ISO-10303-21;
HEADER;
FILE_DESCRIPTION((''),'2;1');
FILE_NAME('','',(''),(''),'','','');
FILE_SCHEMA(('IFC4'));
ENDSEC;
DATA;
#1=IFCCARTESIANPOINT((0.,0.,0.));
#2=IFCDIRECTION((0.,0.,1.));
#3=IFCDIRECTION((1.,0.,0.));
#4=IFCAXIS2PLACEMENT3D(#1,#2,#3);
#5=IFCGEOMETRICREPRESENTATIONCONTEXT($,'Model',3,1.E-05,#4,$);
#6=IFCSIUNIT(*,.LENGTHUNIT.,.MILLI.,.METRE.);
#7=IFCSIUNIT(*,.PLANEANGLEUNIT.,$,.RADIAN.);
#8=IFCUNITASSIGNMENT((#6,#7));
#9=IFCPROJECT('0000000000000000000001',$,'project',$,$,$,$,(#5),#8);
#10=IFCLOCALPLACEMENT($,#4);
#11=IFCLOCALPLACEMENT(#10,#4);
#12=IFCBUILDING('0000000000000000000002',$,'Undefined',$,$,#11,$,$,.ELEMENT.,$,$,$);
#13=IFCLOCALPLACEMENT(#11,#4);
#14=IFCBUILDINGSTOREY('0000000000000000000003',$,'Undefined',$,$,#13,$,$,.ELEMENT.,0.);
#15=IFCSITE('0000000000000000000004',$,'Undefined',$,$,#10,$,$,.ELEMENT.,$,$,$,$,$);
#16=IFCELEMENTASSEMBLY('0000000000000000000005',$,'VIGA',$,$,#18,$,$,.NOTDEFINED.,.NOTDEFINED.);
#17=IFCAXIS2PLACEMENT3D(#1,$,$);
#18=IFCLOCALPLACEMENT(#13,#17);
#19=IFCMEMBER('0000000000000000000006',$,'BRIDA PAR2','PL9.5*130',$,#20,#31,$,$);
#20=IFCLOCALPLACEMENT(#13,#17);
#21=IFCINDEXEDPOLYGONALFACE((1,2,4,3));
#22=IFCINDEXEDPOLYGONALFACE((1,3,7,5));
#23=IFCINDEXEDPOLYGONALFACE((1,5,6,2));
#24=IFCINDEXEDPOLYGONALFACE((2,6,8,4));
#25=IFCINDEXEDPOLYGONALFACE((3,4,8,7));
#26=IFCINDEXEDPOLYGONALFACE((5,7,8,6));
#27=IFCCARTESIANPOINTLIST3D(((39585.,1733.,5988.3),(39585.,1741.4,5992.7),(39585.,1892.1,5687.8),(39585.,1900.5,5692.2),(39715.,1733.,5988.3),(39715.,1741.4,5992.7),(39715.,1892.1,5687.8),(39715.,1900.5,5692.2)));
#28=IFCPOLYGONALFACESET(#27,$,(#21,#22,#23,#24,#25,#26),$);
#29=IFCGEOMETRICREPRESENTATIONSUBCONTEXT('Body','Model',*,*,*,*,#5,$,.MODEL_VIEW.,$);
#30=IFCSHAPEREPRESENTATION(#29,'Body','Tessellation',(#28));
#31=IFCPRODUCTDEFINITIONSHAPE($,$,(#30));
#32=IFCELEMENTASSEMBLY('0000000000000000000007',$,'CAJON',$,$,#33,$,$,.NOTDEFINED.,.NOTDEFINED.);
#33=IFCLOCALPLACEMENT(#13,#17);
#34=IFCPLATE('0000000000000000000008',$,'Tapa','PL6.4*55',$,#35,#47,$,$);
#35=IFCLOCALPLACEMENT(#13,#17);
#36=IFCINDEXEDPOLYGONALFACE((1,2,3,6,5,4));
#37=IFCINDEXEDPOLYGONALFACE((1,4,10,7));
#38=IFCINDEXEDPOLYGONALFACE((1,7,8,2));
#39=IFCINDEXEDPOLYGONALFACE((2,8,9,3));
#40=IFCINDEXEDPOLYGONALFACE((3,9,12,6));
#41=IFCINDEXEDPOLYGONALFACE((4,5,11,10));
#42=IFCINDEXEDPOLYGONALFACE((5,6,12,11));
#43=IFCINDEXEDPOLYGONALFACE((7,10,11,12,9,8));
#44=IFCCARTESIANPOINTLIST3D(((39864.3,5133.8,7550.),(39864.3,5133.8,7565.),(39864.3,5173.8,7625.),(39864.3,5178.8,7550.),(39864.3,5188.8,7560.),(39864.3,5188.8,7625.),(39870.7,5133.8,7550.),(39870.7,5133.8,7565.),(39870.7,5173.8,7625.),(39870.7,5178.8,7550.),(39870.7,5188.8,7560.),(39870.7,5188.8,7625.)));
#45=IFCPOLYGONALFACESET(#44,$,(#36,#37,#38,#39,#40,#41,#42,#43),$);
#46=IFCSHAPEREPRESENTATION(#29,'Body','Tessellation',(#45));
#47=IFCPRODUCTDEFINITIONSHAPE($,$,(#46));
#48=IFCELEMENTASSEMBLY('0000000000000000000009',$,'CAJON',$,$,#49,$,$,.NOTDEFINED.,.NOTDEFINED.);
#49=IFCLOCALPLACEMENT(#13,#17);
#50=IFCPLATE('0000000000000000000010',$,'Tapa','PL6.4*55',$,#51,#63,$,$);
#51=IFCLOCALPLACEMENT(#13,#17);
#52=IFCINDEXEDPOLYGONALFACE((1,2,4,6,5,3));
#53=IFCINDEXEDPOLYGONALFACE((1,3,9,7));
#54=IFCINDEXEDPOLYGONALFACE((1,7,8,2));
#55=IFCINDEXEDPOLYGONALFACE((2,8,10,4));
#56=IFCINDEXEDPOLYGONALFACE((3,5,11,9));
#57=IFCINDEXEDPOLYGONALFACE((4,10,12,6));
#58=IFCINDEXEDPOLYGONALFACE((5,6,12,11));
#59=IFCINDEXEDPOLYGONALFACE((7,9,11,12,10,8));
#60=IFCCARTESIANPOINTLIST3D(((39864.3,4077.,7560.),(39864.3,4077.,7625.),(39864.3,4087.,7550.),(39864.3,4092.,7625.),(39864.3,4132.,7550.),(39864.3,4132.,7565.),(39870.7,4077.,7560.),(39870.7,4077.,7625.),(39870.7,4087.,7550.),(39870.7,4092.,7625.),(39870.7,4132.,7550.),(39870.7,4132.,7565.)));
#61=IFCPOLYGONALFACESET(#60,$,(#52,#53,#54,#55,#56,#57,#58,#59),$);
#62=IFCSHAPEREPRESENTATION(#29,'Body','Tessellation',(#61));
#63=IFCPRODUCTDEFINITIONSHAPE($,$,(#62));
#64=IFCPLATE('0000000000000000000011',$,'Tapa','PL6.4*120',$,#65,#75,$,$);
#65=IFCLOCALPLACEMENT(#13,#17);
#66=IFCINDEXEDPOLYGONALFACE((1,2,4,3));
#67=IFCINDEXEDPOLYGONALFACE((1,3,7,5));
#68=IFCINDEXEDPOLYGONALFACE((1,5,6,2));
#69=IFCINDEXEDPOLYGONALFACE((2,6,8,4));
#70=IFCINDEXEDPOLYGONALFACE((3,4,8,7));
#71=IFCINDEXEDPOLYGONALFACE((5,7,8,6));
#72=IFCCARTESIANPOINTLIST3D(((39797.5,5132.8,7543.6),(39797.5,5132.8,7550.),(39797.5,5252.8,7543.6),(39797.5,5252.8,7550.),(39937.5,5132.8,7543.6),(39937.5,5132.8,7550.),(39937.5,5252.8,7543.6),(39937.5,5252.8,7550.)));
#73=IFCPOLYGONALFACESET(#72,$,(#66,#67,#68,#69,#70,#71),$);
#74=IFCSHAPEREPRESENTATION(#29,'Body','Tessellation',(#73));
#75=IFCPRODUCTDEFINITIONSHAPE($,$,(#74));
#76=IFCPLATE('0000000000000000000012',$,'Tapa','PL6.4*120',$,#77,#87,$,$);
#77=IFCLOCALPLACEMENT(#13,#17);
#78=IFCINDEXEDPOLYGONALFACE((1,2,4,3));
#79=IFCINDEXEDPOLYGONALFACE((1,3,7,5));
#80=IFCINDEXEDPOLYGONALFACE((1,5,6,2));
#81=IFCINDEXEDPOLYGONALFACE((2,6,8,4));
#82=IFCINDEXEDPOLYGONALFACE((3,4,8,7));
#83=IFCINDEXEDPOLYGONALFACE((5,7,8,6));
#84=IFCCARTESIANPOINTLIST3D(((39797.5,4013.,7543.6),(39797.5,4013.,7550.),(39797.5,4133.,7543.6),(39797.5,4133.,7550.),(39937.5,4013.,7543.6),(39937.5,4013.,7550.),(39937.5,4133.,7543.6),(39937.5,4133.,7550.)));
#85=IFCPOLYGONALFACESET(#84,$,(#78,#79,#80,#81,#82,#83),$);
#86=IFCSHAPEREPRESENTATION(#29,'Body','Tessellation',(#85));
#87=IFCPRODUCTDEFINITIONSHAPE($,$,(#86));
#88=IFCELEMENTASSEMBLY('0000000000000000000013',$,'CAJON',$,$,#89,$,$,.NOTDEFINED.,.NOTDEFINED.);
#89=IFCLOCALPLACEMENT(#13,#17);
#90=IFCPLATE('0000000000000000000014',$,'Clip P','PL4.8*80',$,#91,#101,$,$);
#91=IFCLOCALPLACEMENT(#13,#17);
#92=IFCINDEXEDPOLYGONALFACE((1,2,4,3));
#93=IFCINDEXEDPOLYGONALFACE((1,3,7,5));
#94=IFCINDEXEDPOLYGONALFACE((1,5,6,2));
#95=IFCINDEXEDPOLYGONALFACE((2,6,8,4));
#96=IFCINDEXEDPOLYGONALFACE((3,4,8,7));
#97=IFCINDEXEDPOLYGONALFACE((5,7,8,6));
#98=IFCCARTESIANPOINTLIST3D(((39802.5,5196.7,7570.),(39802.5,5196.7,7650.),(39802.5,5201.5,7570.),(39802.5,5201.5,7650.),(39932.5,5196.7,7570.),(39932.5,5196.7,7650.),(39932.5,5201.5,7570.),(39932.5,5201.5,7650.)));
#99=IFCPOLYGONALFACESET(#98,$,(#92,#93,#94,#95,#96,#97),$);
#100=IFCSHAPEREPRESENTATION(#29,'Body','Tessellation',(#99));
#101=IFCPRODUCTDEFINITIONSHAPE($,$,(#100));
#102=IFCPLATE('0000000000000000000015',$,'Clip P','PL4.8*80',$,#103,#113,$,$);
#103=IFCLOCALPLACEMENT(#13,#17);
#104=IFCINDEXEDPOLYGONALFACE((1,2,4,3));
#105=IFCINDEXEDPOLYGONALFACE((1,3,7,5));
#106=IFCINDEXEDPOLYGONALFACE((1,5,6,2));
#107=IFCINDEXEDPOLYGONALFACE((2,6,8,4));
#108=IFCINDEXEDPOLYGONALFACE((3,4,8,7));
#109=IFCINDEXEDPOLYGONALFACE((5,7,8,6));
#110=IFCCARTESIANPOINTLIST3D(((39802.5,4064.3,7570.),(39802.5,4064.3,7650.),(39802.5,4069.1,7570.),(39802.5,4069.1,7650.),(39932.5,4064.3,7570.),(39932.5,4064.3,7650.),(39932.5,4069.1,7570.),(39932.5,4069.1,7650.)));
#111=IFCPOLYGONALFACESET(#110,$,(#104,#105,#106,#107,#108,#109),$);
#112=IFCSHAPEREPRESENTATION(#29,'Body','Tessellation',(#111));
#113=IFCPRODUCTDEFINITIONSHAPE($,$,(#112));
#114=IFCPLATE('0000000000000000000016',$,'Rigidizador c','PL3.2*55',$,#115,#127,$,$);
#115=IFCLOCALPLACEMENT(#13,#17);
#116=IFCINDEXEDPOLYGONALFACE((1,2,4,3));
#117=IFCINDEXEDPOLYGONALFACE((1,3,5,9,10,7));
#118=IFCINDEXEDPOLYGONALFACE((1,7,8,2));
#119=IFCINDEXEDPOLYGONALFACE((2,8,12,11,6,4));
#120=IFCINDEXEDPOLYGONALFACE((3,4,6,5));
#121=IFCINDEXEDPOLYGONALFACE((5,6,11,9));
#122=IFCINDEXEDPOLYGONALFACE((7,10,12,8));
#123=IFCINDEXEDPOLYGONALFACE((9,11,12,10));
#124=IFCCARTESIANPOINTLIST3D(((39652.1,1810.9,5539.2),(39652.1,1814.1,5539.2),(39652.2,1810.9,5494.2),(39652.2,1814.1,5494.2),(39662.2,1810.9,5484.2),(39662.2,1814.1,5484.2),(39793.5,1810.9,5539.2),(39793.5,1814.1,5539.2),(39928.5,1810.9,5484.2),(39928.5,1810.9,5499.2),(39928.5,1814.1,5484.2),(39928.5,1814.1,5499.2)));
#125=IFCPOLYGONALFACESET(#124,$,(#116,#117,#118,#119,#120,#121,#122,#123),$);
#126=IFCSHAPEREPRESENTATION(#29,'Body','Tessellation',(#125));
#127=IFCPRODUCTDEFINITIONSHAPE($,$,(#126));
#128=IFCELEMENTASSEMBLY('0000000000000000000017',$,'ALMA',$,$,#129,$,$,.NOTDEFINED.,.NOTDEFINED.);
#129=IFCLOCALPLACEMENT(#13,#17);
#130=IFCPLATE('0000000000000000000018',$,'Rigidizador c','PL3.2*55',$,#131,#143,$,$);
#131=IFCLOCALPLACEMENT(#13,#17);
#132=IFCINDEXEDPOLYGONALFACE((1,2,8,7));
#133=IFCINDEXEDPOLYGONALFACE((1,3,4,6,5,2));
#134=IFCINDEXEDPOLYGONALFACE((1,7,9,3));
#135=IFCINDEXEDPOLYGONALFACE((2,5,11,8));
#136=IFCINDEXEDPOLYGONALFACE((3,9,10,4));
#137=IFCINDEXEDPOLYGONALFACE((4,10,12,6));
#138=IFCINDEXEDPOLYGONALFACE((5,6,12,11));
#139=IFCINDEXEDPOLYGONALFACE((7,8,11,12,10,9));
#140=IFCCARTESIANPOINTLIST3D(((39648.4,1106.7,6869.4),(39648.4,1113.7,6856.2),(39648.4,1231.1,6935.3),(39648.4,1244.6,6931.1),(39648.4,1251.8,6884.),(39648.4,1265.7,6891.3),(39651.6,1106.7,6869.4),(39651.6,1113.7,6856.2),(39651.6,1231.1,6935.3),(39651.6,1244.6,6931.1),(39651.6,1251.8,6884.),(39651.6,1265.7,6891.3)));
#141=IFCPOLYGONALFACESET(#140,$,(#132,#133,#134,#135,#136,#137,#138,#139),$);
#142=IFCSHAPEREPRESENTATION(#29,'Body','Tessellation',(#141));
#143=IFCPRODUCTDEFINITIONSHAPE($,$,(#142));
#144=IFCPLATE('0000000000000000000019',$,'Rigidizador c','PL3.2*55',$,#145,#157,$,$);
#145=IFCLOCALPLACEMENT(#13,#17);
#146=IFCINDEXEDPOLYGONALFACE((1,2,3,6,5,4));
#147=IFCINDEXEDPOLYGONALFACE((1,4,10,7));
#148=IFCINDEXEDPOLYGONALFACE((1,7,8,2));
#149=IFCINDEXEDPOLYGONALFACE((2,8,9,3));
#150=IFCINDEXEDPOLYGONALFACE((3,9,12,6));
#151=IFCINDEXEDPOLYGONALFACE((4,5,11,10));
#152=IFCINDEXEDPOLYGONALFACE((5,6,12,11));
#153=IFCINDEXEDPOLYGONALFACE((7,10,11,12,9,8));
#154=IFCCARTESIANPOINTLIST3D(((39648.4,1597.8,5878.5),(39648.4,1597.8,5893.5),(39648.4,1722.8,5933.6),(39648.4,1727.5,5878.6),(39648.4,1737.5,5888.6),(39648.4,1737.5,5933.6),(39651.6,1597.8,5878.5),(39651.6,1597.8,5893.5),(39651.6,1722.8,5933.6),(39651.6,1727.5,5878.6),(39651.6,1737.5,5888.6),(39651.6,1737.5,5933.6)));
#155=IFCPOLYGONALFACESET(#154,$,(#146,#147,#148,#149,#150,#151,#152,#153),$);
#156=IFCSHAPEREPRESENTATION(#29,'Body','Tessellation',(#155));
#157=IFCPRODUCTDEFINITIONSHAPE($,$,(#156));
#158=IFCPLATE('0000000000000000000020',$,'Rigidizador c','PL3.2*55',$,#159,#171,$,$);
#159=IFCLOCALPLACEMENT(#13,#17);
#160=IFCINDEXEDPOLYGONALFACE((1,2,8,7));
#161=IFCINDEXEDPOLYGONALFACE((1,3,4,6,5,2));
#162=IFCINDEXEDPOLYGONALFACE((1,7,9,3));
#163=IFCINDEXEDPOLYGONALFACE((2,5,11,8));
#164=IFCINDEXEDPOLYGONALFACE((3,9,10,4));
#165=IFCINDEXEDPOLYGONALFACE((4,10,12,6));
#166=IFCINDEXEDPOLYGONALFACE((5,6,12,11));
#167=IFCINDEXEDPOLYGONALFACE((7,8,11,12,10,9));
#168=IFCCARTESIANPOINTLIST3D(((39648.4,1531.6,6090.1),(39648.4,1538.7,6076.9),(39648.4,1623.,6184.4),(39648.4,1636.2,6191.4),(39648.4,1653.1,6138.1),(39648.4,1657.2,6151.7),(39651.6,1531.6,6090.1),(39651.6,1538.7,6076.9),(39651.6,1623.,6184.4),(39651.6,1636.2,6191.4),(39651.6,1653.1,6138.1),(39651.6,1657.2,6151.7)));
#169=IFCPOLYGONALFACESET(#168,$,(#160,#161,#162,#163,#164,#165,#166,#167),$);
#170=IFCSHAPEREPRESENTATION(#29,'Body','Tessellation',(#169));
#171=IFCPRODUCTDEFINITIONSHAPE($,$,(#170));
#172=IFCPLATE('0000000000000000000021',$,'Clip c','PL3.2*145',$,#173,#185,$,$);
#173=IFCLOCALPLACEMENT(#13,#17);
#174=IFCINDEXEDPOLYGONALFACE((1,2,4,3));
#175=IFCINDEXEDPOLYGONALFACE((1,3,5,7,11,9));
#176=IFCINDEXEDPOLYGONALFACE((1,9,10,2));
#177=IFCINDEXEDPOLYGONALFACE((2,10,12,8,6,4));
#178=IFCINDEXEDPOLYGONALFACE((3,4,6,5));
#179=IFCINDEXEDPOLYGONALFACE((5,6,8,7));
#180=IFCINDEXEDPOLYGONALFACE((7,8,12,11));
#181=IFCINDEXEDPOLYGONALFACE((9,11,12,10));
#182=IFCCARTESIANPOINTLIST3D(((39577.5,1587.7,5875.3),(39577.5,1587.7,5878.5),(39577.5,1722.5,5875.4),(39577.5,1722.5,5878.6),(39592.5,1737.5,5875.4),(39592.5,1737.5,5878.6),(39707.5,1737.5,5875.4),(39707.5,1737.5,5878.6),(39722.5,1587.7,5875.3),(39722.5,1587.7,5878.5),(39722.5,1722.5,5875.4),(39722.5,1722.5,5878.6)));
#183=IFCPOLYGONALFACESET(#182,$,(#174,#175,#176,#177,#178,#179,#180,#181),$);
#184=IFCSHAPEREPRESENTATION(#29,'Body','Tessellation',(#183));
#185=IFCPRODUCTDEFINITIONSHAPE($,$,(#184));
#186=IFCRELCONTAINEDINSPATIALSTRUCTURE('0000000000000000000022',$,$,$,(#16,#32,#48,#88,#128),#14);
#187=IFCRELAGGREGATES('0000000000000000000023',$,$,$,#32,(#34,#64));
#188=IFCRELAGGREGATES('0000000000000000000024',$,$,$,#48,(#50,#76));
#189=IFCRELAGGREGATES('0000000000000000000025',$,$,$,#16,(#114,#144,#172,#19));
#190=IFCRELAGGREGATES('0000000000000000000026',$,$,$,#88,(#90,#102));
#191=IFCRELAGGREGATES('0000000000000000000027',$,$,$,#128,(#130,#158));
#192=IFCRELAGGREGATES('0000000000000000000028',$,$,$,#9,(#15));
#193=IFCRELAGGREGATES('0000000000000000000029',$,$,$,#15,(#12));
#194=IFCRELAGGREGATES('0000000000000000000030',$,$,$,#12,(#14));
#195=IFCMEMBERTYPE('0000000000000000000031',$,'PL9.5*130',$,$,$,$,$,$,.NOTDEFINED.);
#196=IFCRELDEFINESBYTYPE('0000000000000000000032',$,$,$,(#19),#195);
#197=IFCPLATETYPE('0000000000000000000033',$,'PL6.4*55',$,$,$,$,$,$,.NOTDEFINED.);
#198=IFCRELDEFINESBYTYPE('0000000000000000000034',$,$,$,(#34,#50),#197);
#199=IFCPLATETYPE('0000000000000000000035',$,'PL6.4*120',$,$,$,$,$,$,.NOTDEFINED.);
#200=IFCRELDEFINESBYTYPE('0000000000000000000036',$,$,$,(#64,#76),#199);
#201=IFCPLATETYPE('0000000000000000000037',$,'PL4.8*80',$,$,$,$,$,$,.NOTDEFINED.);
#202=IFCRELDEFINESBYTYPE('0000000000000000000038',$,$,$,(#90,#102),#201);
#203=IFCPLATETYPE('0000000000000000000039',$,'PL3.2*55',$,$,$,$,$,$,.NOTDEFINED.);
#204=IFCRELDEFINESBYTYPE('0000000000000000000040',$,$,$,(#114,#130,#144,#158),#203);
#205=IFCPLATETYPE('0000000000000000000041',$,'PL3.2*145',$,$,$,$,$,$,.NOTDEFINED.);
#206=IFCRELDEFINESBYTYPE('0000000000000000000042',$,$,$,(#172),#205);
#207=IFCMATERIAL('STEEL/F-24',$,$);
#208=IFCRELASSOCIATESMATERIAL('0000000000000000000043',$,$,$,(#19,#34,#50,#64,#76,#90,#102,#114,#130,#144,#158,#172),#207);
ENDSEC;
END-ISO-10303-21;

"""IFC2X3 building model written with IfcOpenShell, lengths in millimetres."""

from ifc_helpers import new_model, si_unit, frame, origin_with_axes, origin_2d_with_axis, place, context, subcontext, project, spatial, polyline, rectangle, outline, extrude, material, type_object, element, aggregate, save


model = new_model("IFC2X3")

# Units and contexts
model_context = context("Model", 3, precision=1e-05, world=origin_with_axes())
body_context = subcontext(model_context, "Body", "Model", "MODEL_VIEW")
ifc_project = project(units=[si_unit("LENGTHUNIT", "METRE", prefix="MILLI"), si_unit("PLANEANGLEUNIT", "RADIAN")], contexts=[model_context])

# Site, building, storey
site_placement = place(None, origin_with_axes())
site = spatial("IfcSite", under=ifc_project, at=site_placement, Name="Undefined", CompositionType="ELEMENT")
building_placement = place(site_placement, origin_with_axes())
building = spatial("IfcBuilding", under=site, at=building_placement, Name="Undefined", CompositionType="ELEMENT")
storey_placement = place(building_placement, origin_with_axes())
storey = spatial("IfcBuildingStorey", under=building, at=storey_placement, Name="Undefined", CompositionType="ELEMENT", Elevation=0.0)

# Element assembly, member
assembly_1_placement = place(storey_placement, origin_with_axes())
assembly_1 = element("IfcElementAssembly", 1, at=assembly_1_placement, inside=storey, Name="VIGA", AssemblyPlace="NOTDEFINED", PredefinedType="NOTDEFINED")
ifc_material_1 = material(Name="STEEL/F-24")
member_type = type_object("IfcMemberType", Name="PL9.5*130", PredefinedType="NOTDEFINED")
member_placement = place(assembly_1_placement, frame((39650.0, 1896.3, 5690.0), z_axis=(-1.0, 0.0, 0.0), x_axis=(0.0, -0.467888, 0.883788)))
member = element("IfcMember", 2, at=member_placement, type_object=member_type, material=ifc_material_1, Name="BRIDA PAR2", Description="PL9.5*130", context=body_context, shape_type="SweptSolid", body=[
    extrude(rectangle(XDim=9.5, YDim=130.0, at=origin_2d_with_axis()), frame((340.0, 0.0, 0.0), z_axis=(-1.0, 0.0, 0.0), x_axis=(0.0, -1.0, 0.0)), (0.0, 0.0, 1.0), 340.0),
])

# Element assemblies, plates
assembly_2_placement = place(storey_placement, origin_with_axes())
assembly_2 = element("IfcElementAssembly", 3, at=assembly_2_placement, inside=storey, Name="CAJON", AssemblyPlace="NOTDEFINED", PredefinedType="NOTDEFINED")
plate_type_1 = type_object("IfcPlateType", Name="PL6.4*55", PredefinedType="NOTDEFINED")
plate_1_placement = place(assembly_2_placement, frame((39867.5, 5188.8, 7625.0), z_axis=(-1.0, 0.0, 0.0), x_axis=(0.0, 0.000064, -1.0)))
plate_1 = element("IfcPlate", 4, at=plate_1_placement, type_object=plate_type_1, material=ifc_material_1, Name="Tapa", Description="PL6.4*55", context=body_context, shape_type="SweptSolid", body=[
    extrude(outline(polyline([(0.0, 0.0), (65.0, 0.0), (75.0, 10.0), (75.0, 55.0), (60.0, 55.0), (0.0, 15.0), (0.0, 0.0)])), frame((0.0, 0.0, -3.2), z_axis=(0.0, 0.0, 1.0), x_axis=(1.0, 0.0, 0.0)), (0.0, 0.0, 1.0), 6.4),
])
assembly_3_placement = place(storey_placement, origin_with_axes())
assembly_3 = element("IfcElementAssembly", 5, at=assembly_3_placement, inside=storey, Name="CAJON", AssemblyPlace="NOTDEFINED", PredefinedType="NOTDEFINED")
plate_2_placement = place(assembly_3_placement, frame((39867.5, 4077.0, 7625.0), z_axis=(1.0, 0.0, 0.0), x_axis=(0.0, -0.000064, -1.0)))
plate_2 = element("IfcPlate", 6, at=plate_2_placement, type_object=plate_type_1, material=ifc_material_1, Name="Tapa", Description="PL6.4*55", context=body_context, shape_type="SweptSolid", body=[
    extrude(outline(polyline([(0.0, 0.0), (65.0, 0.0), (75.0, 10.0), (75.0, 55.0), (60.0, 55.0), (0.0, 15.0), (0.0, 0.0)])), frame((0.0, 0.0, -3.2), z_axis=(0.0, 0.0, 1.0), x_axis=(1.0, 0.0, 0.0)), (0.0, 0.0, 1.0), 6.4),
])

# Plates
plate_type_2 = type_object("IfcPlateType", Name="PL6.4*120", PredefinedType="NOTDEFINED")
plate_3_placement = place(assembly_2_placement, frame((39937.5, 5132.8, 7546.8), z_axis=(0.0, -0.000039, 1.0), x_axis=(0.0, 1.0, 0.000039)))
plate_3 = element("IfcPlate", 7, at=plate_3_placement, type_object=plate_type_2, material=ifc_material_1, Name="Tapa", Description="PL6.4*120", context=body_context, shape_type="SweptSolid", body=[
    extrude(outline(polyline([(0.0, 0.0), (120.0, 0.0), (120.0, 140.0), (0.0, 140.0), (0.0, 0.0)])), frame((0.0, 0.0, -3.2), z_axis=(0.0, 0.0, 1.0), x_axis=(1.0, 0.0, 0.0)), (0.0, 0.0, 1.0), 6.4),
])
aggregate(assembly_2, [plate_1, plate_3])
plate_4_placement = place(assembly_3_placement, frame((39937.5, 4133.0, 7546.8), z_axis=(0.0, -0.000039, -1.0), x_axis=(0.0, -1.0, 0.000039)))
plate_4 = element("IfcPlate", 8, at=plate_4_placement, type_object=plate_type_2, material=ifc_material_1, Name="Tapa", Description="PL6.4*120", context=body_context, shape_type="SweptSolid", body=[
    extrude(outline(polyline([(0.0, 0.0), (120.0, 0.0), (120.0, 140.0), (0.0, 140.0), (0.0, 0.0)])), frame((0.0, 0.0, -3.2), z_axis=(0.0, 0.0, 1.0), x_axis=(1.0, 0.0, 0.0)), (0.0, 0.0, 1.0), 6.4),
])
aggregate(assembly_3, [plate_2, plate_4])

# Element assembly, plates
assembly_4_placement = place(storey_placement, origin_with_axes())
assembly_4 = element("IfcElementAssembly", 9, at=assembly_4_placement, inside=storey, Name="CAJON", AssemblyPlace="NOTDEFINED", PredefinedType="NOTDEFINED")
plate_type_3 = type_object("IfcPlateType", Name="PL4.8*80", PredefinedType="NOTDEFINED")
plate_5_placement = place(assembly_4_placement, frame((39802.5, 5199.1, 7570.0), z_axis=(0.0, -1.0, -0.000052), x_axis=(1.0, 0.0, 0.0)))
plate_5 = element("IfcPlate", 10, at=plate_5_placement, type_object=plate_type_3, material=ifc_material_1, Name="Clip P", Description="PL4.8*80", context=body_context, shape_type="SweptSolid", body=[
    extrude(outline(polyline([(0.0, 0.0), (130.0, 0.0), (130.0, 80.0), (0.0, 80.0), (0.0, 0.0)])), frame((0.0, 0.0, -2.4), z_axis=(0.0, 0.0, 1.0), x_axis=(1.0, 0.0, 0.0)), (0.0, 0.0, 1.0), 4.8),
])
plate_6_placement = place(assembly_4_placement, frame((39802.5, 4066.7, 7570.0), z_axis=(0.0, -1.0, 0.000052), x_axis=(1.0, 0.0, 0.0)))
plate_6 = element("IfcPlate", 11, at=plate_6_placement, type_object=plate_type_3, material=ifc_material_1, Name="Clip P", Description="PL4.8*80", context=body_context, shape_type="SweptSolid", body=[
    extrude(outline(polyline([(0.0, 0.0), (130.0, 0.0), (130.0, 80.0), (0.0, 80.0), (0.0, 0.0)])), frame((0.0, 0.0, -2.4), z_axis=(0.0, 0.0, 1.0), x_axis=(1.0, 0.0, 0.0)), (0.0, 0.0, 1.0), 4.8),
])

# Plate
plate_type_4 = type_object("IfcPlateType", Name="PL3.2*55", PredefinedType="NOTDEFINED")
plate_7_placement = place(assembly_1_placement, frame((39928.5, 1812.5, 5484.2), z_axis=(0.0, -1.0, 0.0), x_axis=(-0.000128, 0.0, 1.0)))
plate_7 = element("IfcPlate", 12, at=plate_7_placement, type_object=plate_type_4, material=ifc_material_1, Name="Rigidizador c", Description="PL3.2*55", context=body_context, shape_type="SweptSolid", body=[
    extrude(outline(polyline([(0.0, 0.0), (15.0, 0.0), (55.0, 135.0), (55.0, 276.4), (10.0, 276.3), (0.0, 266.3), (0.0, 0.0)])), frame((0.0, 0.0, -1.6), z_axis=(0.0, 0.0, 1.0), x_axis=(1.0, 0.0, 0.0)), (0.0, 0.0, 1.0), 3.2),
])

# Element assembly, plate
assembly_5_placement = place(storey_placement, origin_with_axes())
assembly_5 = element("IfcElementAssembly", 13, at=assembly_5_placement, inside=storey, Name="ALMA", AssemblyPlace="NOTDEFINED", PredefinedType="NOTDEFINED")
plate_8_placement = place(assembly_5_placement, frame((39650.0, 1106.7, 6869.4), z_axis=(1.0, 0.0, 0.0), x_axis=(0.0, 0.467929, -0.883766)))
plate_8 = element("IfcPlate", 14, at=plate_8_placement, type_object=plate_type_4, material=ifc_material_1, Name="Rigidizador c", Description="PL3.2*55", context=body_context, shape_type="SweptSolid", body=[
    extrude(outline(polyline([(0.0, 0.0), (15.0, 0.0), (55.0, 135.0), (55.0, 150.7), (10.0, 150.7), (0.0, 140.7), (0.0, 0.0)])), frame((0.0, 0.0, -1.6), z_axis=(0.0, 0.0, 1.0), x_axis=(1.0, 0.0, 0.0)), (0.0, 0.0, 1.0), 3.2),
])

# Plates
plate_9_placement = place(assembly_1_placement, frame((39650.0, 1597.8, 5878.5), z_axis=(-1.0, 0.0, 0.0), x_axis=(0.0, -0.000528, 1.0)))
plate_9 = element("IfcPlate", 15, at=plate_9_placement, type_object=plate_type_4, material=ifc_material_1, Name="Rigidizador c", Description="PL3.2*55", context=body_context, shape_type="SweptSolid", body=[
    extrude(outline(polyline([(0.0, 0.0), (15.0, 0.0), (55.0, 125.0), (55.0, 139.8), (10.0, 139.7), (0.0, 129.7), (0.0, 0.0)])), frame((0.0, 0.0, -1.6), z_axis=(0.0, 0.0, 1.0), x_axis=(1.0, 0.0, 0.0)), (0.0, 0.0, 1.0), 3.2),
])
plate_10_placement = place(assembly_5_placement, frame((39650.0, 1538.7, 6076.9), z_axis=(-1.0, 0.0, 0.0), x_axis=(0.0, -0.471722, 0.881748)))
plate_10 = element("IfcPlate", 16, at=plate_10_placement, type_object=plate_type_4, material=ifc_material_1, Name="Rigidizador c", Description="PL3.2*55", context=body_context, shape_type="SweptSolid", body=[
    extrude(outline(polyline([(0.0, 0.0), (15.0, 0.0), (55.0, 125.0), (55.0, 140.0), (10.0, 139.8), (0.0, 129.7), (0.0, 0.0)])), frame((0.0, 0.0, -1.6), z_axis=(0.0, 0.0, 1.0), x_axis=(1.0, 0.0, 0.0)), (0.0, 0.0, 1.0), 3.2),
])
plate_type_5 = type_object("IfcPlateType", Name="PL3.2*145", PredefinedType="NOTDEFINED")
plate_11_placement = place(assembly_1_placement, frame((39722.5, 1737.5, 5877.0), z_axis=(0.0, 0.000384, -1.0), x_axis=(0.0, -1.0, -0.000384)))
plate_11 = element("IfcPlate", 17, at=plate_11_placement, type_object=plate_type_5, material=ifc_material_1, Name="Clip c", Description="PL3.2*145", context=body_context, shape_type="SweptSolid", body=[
    extrude(outline(polyline([(0.0, 15.0), (15.0, 0.0), (149.8, 0.0), (149.8, 145.0), (15.0, 145.0), (0.0, 130.0), (0.0, 15.0)])), frame((0.0, 0.0, -1.6), z_axis=(0.0, 0.0, 1.0), x_axis=(1.0, 0.0, 0.0)), (0.0, 0.0, 1.0), 3.2),
])
aggregate(assembly_1, [plate_7, plate_9, plate_11, member])

aggregate(assembly_4, [plate_5, plate_6])

aggregate(assembly_5, [plate_8, plate_10])

save(model, "model.ifc")
